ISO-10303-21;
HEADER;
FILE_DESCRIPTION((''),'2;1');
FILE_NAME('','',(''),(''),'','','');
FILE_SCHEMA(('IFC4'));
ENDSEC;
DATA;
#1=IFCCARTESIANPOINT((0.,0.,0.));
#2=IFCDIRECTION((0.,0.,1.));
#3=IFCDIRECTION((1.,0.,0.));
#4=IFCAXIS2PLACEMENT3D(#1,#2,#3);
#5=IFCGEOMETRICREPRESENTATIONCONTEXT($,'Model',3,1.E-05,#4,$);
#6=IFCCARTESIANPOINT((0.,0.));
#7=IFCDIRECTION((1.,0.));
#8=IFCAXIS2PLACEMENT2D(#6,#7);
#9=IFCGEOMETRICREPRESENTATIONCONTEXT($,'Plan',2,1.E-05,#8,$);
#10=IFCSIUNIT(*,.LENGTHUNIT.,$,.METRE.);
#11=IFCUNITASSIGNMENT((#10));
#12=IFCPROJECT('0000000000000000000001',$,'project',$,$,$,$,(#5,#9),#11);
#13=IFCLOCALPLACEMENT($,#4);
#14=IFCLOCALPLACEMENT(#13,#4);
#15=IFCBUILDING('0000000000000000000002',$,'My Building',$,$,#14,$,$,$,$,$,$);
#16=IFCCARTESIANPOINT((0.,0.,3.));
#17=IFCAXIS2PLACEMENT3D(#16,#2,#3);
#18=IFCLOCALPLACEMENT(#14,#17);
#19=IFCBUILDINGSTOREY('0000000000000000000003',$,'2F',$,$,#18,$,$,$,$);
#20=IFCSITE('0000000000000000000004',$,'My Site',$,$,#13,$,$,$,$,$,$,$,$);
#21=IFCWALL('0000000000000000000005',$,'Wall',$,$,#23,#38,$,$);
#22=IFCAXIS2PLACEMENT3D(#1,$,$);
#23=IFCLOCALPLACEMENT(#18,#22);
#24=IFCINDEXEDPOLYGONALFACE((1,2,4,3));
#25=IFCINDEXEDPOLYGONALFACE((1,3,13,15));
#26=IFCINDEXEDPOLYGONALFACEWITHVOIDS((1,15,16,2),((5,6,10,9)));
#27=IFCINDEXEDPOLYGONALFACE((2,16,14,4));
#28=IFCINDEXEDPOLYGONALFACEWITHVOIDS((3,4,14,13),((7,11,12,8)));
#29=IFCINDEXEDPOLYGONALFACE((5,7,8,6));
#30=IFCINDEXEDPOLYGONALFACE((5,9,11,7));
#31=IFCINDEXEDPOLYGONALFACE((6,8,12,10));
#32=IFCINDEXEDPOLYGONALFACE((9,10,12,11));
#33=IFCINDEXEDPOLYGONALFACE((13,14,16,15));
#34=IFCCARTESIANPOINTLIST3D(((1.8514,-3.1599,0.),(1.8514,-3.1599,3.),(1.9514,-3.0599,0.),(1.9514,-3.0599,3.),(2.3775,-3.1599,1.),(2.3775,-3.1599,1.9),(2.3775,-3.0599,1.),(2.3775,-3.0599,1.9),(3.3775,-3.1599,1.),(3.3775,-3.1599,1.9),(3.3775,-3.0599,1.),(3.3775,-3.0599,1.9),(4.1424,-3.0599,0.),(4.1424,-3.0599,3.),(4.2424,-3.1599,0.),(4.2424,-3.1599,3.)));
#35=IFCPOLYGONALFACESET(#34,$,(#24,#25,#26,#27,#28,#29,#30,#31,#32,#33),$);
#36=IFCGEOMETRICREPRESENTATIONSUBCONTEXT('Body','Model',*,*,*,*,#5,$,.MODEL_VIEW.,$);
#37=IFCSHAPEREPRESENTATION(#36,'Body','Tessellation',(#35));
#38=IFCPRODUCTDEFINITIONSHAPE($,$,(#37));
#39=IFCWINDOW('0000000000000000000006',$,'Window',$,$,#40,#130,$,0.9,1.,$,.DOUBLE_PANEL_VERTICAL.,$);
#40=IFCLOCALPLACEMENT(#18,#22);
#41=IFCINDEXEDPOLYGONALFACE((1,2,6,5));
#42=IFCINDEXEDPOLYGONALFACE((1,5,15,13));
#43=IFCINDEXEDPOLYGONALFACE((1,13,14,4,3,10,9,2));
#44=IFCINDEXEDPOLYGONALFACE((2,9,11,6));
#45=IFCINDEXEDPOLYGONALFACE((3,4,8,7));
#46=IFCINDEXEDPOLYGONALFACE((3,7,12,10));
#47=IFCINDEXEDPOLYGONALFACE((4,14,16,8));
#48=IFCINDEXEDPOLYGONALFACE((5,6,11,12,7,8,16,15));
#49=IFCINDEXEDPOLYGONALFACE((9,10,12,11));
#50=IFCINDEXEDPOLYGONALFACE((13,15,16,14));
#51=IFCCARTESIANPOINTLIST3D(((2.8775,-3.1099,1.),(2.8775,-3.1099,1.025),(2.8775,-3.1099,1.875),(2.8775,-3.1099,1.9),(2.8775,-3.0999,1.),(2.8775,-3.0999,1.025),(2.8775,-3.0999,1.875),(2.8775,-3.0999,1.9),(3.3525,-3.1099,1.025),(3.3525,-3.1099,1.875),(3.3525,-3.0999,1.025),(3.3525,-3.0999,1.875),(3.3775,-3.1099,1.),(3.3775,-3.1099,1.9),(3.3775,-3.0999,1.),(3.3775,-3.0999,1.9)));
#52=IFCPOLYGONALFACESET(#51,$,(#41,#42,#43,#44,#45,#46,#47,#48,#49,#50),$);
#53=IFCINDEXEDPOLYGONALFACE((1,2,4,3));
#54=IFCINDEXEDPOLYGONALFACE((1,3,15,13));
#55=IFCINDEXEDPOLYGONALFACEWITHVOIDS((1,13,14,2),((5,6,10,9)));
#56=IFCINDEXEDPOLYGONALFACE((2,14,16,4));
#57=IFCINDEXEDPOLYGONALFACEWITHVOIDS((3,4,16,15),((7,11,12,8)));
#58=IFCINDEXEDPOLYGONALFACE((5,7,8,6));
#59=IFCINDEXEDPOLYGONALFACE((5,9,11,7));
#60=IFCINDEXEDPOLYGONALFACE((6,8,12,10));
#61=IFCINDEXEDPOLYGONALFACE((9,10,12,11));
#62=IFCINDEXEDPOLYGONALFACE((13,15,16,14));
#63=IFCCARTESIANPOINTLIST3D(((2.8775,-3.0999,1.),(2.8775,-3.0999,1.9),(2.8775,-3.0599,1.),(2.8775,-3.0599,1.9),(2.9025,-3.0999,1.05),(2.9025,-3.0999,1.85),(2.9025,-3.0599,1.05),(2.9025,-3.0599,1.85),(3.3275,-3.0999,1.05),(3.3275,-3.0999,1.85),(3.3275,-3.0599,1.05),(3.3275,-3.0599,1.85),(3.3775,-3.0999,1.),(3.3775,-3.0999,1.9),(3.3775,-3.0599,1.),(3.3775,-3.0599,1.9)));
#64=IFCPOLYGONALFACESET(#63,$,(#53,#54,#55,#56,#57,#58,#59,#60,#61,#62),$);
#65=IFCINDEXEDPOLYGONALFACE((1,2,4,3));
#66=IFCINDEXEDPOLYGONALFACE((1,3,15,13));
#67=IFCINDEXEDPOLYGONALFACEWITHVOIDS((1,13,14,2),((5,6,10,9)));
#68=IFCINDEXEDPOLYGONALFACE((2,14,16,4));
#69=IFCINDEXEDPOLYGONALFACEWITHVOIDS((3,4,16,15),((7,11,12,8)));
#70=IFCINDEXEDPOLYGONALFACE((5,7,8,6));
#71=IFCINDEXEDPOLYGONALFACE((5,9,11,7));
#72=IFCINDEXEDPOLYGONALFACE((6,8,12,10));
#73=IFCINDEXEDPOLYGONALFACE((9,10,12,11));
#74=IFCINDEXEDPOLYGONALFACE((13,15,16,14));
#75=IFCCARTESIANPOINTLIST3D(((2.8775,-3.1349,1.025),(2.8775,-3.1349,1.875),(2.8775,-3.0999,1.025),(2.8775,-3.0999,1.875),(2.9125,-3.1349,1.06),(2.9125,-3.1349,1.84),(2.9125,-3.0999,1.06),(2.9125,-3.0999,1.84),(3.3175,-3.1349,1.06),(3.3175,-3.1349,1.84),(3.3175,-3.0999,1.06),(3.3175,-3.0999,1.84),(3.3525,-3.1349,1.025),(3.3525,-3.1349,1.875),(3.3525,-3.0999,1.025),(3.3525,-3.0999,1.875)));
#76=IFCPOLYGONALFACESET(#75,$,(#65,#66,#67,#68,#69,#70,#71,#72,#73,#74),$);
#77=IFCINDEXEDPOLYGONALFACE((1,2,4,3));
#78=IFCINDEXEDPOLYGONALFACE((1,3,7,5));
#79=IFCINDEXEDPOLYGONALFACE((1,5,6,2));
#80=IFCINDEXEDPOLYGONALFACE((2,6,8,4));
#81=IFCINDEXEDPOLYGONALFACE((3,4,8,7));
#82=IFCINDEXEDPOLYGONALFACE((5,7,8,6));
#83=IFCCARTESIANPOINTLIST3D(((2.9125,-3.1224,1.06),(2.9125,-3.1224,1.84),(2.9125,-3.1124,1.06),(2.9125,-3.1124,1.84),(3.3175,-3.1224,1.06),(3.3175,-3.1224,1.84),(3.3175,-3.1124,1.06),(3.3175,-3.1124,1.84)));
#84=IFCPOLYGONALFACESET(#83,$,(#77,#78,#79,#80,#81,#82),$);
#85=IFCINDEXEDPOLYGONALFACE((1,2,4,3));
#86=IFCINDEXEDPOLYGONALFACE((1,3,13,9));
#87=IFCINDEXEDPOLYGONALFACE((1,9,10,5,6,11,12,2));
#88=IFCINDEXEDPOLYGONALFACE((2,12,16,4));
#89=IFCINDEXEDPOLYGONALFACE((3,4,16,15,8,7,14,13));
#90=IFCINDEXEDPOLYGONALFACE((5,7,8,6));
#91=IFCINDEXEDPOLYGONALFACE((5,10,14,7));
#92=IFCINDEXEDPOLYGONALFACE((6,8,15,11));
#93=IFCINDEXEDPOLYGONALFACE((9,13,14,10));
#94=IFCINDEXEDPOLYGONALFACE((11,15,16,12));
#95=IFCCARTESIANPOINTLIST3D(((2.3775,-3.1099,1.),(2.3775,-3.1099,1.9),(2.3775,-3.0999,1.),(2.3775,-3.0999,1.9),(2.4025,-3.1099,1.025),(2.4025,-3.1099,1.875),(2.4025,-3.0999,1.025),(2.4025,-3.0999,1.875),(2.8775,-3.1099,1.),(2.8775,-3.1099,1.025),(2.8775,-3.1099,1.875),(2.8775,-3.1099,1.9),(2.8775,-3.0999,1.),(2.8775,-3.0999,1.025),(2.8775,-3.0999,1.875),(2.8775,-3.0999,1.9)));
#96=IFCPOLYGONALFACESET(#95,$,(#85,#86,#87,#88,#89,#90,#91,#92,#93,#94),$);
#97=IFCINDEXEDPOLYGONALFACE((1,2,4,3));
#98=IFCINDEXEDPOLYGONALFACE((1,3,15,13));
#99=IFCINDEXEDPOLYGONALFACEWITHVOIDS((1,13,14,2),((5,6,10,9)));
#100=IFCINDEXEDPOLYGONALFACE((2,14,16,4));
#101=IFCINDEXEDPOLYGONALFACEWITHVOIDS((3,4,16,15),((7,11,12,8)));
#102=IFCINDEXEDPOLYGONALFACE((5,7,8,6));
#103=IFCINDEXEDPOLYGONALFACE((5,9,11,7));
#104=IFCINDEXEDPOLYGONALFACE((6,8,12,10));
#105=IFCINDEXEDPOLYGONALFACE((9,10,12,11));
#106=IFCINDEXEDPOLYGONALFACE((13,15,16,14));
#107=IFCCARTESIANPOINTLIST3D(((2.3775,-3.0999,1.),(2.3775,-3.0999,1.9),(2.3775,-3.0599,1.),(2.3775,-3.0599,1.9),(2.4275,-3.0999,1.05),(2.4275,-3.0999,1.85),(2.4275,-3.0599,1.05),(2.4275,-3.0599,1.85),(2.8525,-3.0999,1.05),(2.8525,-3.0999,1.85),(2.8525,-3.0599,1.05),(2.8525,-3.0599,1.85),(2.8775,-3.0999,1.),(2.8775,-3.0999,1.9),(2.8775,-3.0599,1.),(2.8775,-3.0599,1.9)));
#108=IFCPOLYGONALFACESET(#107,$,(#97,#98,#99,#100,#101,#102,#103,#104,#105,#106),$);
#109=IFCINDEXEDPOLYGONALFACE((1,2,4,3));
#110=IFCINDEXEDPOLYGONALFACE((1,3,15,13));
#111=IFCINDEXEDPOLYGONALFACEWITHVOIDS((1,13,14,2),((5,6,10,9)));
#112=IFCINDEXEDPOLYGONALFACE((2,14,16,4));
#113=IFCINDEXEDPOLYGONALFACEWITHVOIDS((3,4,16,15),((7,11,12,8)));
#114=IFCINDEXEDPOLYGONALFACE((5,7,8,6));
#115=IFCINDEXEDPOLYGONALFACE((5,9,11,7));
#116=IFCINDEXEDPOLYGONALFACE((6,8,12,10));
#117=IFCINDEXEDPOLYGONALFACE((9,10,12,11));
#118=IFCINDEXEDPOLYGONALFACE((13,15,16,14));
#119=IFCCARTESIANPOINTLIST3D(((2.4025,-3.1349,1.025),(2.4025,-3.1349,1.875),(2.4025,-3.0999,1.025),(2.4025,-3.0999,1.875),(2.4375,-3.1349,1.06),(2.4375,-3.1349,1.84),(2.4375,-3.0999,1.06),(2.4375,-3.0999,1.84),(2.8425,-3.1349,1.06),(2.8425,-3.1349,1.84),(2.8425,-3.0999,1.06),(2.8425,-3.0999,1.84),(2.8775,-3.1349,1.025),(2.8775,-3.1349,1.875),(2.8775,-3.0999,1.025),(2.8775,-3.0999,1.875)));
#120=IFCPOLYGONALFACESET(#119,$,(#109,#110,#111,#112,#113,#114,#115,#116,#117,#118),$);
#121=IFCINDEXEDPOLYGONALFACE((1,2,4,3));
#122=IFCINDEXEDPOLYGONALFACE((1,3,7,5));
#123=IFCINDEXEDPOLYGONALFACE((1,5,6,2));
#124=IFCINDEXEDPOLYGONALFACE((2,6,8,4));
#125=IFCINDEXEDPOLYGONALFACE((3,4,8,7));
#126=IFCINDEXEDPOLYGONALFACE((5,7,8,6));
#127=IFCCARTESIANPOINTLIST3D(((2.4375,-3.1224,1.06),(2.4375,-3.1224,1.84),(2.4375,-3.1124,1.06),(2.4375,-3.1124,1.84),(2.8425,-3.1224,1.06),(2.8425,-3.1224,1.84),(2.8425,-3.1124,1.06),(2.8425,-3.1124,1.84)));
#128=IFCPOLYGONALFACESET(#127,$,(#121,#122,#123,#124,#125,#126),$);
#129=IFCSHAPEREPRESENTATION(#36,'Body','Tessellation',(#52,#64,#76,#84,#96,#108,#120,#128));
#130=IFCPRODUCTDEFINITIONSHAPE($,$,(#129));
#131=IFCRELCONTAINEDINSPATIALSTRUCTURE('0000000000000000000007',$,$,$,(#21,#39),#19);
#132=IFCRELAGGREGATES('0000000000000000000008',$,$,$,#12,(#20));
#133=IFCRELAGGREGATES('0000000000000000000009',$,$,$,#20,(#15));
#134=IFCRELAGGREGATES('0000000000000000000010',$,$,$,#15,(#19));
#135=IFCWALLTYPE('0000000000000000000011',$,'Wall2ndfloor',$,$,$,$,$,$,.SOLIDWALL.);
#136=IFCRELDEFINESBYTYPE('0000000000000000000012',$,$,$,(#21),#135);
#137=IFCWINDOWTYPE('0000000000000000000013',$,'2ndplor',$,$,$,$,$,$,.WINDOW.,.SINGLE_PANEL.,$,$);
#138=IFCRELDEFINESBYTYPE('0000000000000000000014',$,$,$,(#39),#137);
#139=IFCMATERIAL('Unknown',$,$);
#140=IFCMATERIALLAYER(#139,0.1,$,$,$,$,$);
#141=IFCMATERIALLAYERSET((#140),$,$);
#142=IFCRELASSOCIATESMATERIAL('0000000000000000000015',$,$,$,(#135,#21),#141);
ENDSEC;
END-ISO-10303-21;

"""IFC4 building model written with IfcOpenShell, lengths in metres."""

from ifc_helpers import new_model, entity, si_unit, frame, origin_with_axes, origin_2d_with_axis, place, context, subcontext, project, spatial, line, indexed_curve, outline, extrude, shape, source, transform, mapped, material, layer, layer_set, layer_usage, type_object, type_shapes, element, fill, save


model = new_model("IFC4")

# Units and contexts
model_context = context("Model", 3, precision=1e-05, world=origin_with_axes())
plan_context = context("Plan", 2, precision=1e-05, world=origin_2d_with_axis())
body_context_1 = subcontext(model_context, "Body", "Model", "MODEL_VIEW")
body_context_2 = subcontext(plan_context, "Body", "Plan", "PLAN_VIEW")
ifc_project = project(units=[si_unit("LENGTHUNIT", "METRE")], contexts=[model_context, plan_context])

# Site, building, storey
site_placement = place(None, origin_with_axes())
site = spatial("IfcSite", under=ifc_project, at=site_placement, Name="My Site")
building_placement = place(site_placement, origin_with_axes())
building = spatial("IfcBuilding", under=site, at=building_placement, Name="My Building")
storey_placement = place(building_placement, frame((0.0, 0.0, 3.0), z_axis=(0.0, 0.0, 1.0), x_axis=(1.0, 0.0, 0.0)))
storey = spatial("IfcBuildingStorey", under=building, at=storey_placement, Name="2F")

# Shared definitions
ifc_material = material(Name="Unknown")

# Shared definitions
ifc_layer_1 = layer(ifc_material, 0.1)
ifc_layer_set_1 = layer_set([ifc_layer_1])
wall_type = type_object("IfcWallType", Name="Wall2ndfloor", PredefinedType="SOLIDWALL", material=ifc_layer_set_1)

# Shared definitions
shared_shape_1 = source(origin_with_axes(), body_context_1, "Body", "SweptSolid", [
    extrude(outline(indexed_curve([(0.0, 0.0), (1.0, 0.0), (1.0, 0.9), (0.0, 0.9)], segments=[line(1, 2, 3, 4, 1)])), frame((0.0, -0.6, 0.0), z_axis=(0.0, -1.0, 0.0), x_axis=(1.0, 0.0, 0.0)), (0.0, 0.0, -1.0), 1.2),
])
window_type_1 = type_object("IfcWindowType", Name="2ndplor", PartitioningType="SINGLE_PANEL", PredefinedType="WINDOW")
shared_shape_2 = source(origin_with_axes(), body_context_1, "Body", "SweptSolid", [
    extrude(outline(indexed_curve([(0.5, 0.0), (0.0, 0.0), (0.0, 0.9), (0.5, 0.9), (0.5, 0.875), (0.025, 0.875), (0.025, 0.025), (0.5, 0.025)], segments=[line(1, 2, 3, 4, 5, 6, 7, 8, 1)])), frame((0.0, 0.09, 0.0), z_axis=(0.0, -1.0, 0.0), x_axis=(1.0, 0.0, 0.0)), (0.0, 0.0, -1.0), 0.01),
    extrude(outline(indexed_curve([(0.0, 0.0), (0.5, 0.0), (0.5, 0.9), (0.0, 0.9)], segments=[line(1, 2, 3, 4, 1)]), holes=[indexed_curve([(0.05, 0.05), (0.475, 0.05), (0.475, 0.85), (0.05, 0.85)], segments=[line(1, 2, 3, 4, 1)])]), frame((0.0, 0.05, 0.0), z_axis=(0.0, -1.0, 0.0), x_axis=(1.0, 0.0, 0.0)), (0.0, 0.0, -1.0), 0.04),
    extrude(outline(indexed_curve([(0.0, 0.0), (0.475, 0.0), (0.475, 0.85), (0.0, 0.85)], segments=[line(1, 2, 3, 4, 1)]), holes=[indexed_curve([(0.035, 0.035), (0.44, 0.035), (0.44, 0.815), (0.035, 0.815)], segments=[line(1, 2, 3, 4, 1)])]), frame((0.025, 0.09, 0.025), z_axis=(0.0, -1.0, 0.0), x_axis=(1.0, 0.0, 0.0)), (0.0, 0.0, -1.0), 0.035),
    extrude(outline(indexed_curve([(0.035, 0.035), (0.44, 0.035), (0.44, 0.815), (0.035, 0.815)], segments=[line(1, 2, 3, 4, 1)])), frame((0.025, 0.1025, 0.025), z_axis=(0.0, -1.0, 0.0), x_axis=(1.0, 0.0, 0.0)), (0.0, 0.0, -1.0), 0.01),
    extrude(outline(indexed_curve([(0.0, 0.9), (0.5, 0.9), (0.5, 0.0), (0.0, 0.0), (0.0, 0.025), (0.475, 0.025), (0.475, 0.875), (0.0, 0.875)], segments=[line(1, 2, 3, 4, 5, 6, 7, 8, 1)])), frame((0.5, 0.09, 0.0), z_axis=(0.0, -1.0, 0.0), x_axis=(1.0, 0.0, 0.0)), (0.0, 0.0, -1.0), 0.01),
    extrude(outline(indexed_curve([(0.0, 0.0), (0.5, 0.0), (0.5, 0.9), (0.0, 0.9)], segments=[line(1, 2, 3, 4, 1)]), holes=[indexed_curve([(0.025, 0.05), (0.45, 0.05), (0.45, 0.85), (0.025, 0.85)], segments=[line(1, 2, 3, 4, 1)])]), frame((0.5, 0.05, 0.0), z_axis=(0.0, -1.0, 0.0), x_axis=(1.0, 0.0, 0.0)), (0.0, 0.0, -1.0), 0.04),
    extrude(outline(indexed_curve([(0.0, 0.0), (0.475, 0.0), (0.475, 0.85), (0.0, 0.85)], segments=[line(1, 2, 3, 4, 1)]), holes=[indexed_curve([(0.035, 0.035), (0.44, 0.035), (0.44, 0.815), (0.035, 0.815)], segments=[line(1, 2, 3, 4, 1)])]), frame((0.5, 0.09, 0.025), z_axis=(0.0, -1.0, 0.0), x_axis=(1.0, 0.0, 0.0)), (0.0, 0.0, -1.0), 0.035),
    extrude(outline(indexed_curve([(0.035, 0.035), (0.44, 0.035), (0.44, 0.815), (0.035, 0.815)], segments=[line(1, 2, 3, 4, 1)])), frame((0.5, 0.1025, 0.025), z_axis=(0.0, -1.0, 0.0), x_axis=(1.0, 0.0, 0.0)), (0.0, 0.0, -1.0), 0.01),
])
shared_shape_3 = source(origin_with_axes(), body_context_2, "Body", "Curve2D", [
    entity("IfcIndexedPolyCurve", entity("IfcCartesianPointList2D", [[0.05, 0.05], [0.475, 0.05]])),
    entity("IfcIndexedPolyCurve", entity("IfcCartesianPointList2D", [[0.0, 0.1], [0.025, 0.1], [0.025, 0.09], [0.05, 0.09], [0.05, 0.05], [0.0, 0.05]]), [entity("IfcLineIndex", [1, 2, 3, 4, 5, 6, 1])]),
    entity("IfcIndexedPolyCurve", entity("IfcCartesianPointList2D", [[0.5, 0.1], [0.5, 0.1], [0.5, 0.09], [0.475, 0.09], [0.475, 0.05], [0.5, 0.05]])),
    entity("IfcIndexedPolyCurve", entity("IfcCartesianPointList2D", [[0.025, 0.09], [0.06, 0.09], [0.06, 0.125], [0.025, 0.125]]), [entity("IfcLineIndex", [1, 2, 3, 4, 1])]),
    entity("IfcIndexedPolyCurve", entity("IfcCartesianPointList2D", [[0.5, 0.09], [0.465, 0.09], [0.465, 0.125], [0.5, 0.125]]), [entity("IfcLineIndex", [1, 2, 3, 4, 1])]),
    entity("IfcIndexedPolyCurve", entity("IfcCartesianPointList2D", [[0.06, 0.09], [0.465, 0.09]])),
    entity("IfcIndexedPolyCurve", entity("IfcCartesianPointList2D", [[0.06, 0.125], [0.465, 0.125]])),
    entity("IfcIndexedPolyCurve", entity("IfcCartesianPointList2D", [[0.06, 0.1075], [0.465, 0.1075]])),
    entity("IfcIndexedPolyCurve", entity("IfcCartesianPointList2D", [[0.525, 0.05], [0.95, 0.05]])),
    entity("IfcIndexedPolyCurve", entity("IfcCartesianPointList2D", [[0.5, 0.1], [0.5, 0.1], [0.5, 0.09], [0.525, 0.09], [0.525, 0.05], [0.5, 0.05]])),
    entity("IfcIndexedPolyCurve", entity("IfcCartesianPointList2D", [[1.0, 0.1], [0.975, 0.1], [0.975, 0.09], [0.95, 0.09], [0.95, 0.05], [1.0, 0.05]]), [entity("IfcLineIndex", [1, 2, 3, 4, 5, 6, 1])]),
    entity("IfcIndexedPolyCurve", entity("IfcCartesianPointList2D", [[0.5, 0.09], [0.535, 0.09], [0.535, 0.125], [0.5, 0.125]]), [entity("IfcLineIndex", [1, 2, 3, 4, 1])]),
    entity("IfcIndexedPolyCurve", entity("IfcCartesianPointList2D", [[0.975, 0.09], [0.94, 0.09], [0.94, 0.125], [0.975, 0.125]]), [entity("IfcLineIndex", [1, 2, 3, 4, 1])]),
    entity("IfcIndexedPolyCurve", entity("IfcCartesianPointList2D", [[0.535, 0.09], [0.94, 0.09]])),
    entity("IfcIndexedPolyCurve", entity("IfcCartesianPointList2D", [[0.535, 0.125], [0.94, 0.125]])),
    entity("IfcIndexedPolyCurve", entity("IfcCartesianPointList2D", [[0.535, 0.1075], [0.94, 0.1075]])),
])
type_shapes(window_type_1, [shared_shape_2, shared_shape_3])

# Wall, opening, window
ifc_layer_usage_1 = layer_usage(ifc_layer_set_1, "AXIS2", "POSITIVE", 0.0)
wall_1_placement = place(storey_placement, frame((1.8514, -3.1599, 0.0), z_axis=(0.0, 0.0, 1.0), x_axis=(1.0, 0.0, 0.0)))
wall_1 = element("IfcWall", 1, at=wall_1_placement, inside=storey, type_object=wall_type, material=ifc_layer_usage_1, Name="Wall", context=body_context_1, shape_type="SweptSolid", body=[
    extrude(outline(indexed_curve([(0.0, 0.0), (0.1, 0.1), (2.291, 0.1), (2.391, 0.0)], segments=[line(1, 2, 3, 4, 1)])), origin_with_axes(), (0.0, 0.0, 1.0), 3.0),
])
opening_1_placement = place(wall_1_placement, frame((1.5262, 0.15, 1.0), z_axis=(0.0, 0.0, 1.0), x_axis=(-1.0, 0.000001, 0.0)))
opening_1 = element("IfcOpeningElement", 2, at=opening_1_placement, cuts=wall_1, PredefinedType="OPENING", context=body_context_1, shape_type="MappedRepresentation", body=[
    mapped(shared_shape_1, transform((0.0, 0.0, 0.0), x_axis=(1.0, 0.0, 0.0), y_axis=(0.0, 1.0, 0.0), z_axis=(0.0, 0.0, 1.0), scale=1.0)),
])
window_1_placement = place(opening_1_placement, origin_with_axes())
window_1 = element("IfcWindow", 3, at=window_1_placement, inside=storey, type_object=window_type_1, Name="Window", OverallHeight=0.9, OverallWidth=1.0, PartitioningType="DOUBLE_PANEL_VERTICAL", shapes=[
    shape(body_context_1, "Body", "MappedRepresentation", [mapped(shared_shape_2, transform((0.0, 0.0, 0.0), x_axis=(1.0, 0.0, 0.0), y_axis=(0.0, 1.0, 0.0), z_axis=(0.0, 0.0, 1.0), scale=1.0))]),
    shape(body_context_2, "Body", "MappedRepresentation", [mapped(shared_shape_3, transform((0.0, 0.0, 0.0), x_axis=(1.0, 0.0, 0.0), y_axis=(0.0, 1.0, 0.0), z_axis=(0.0, 0.0, 1.0), scale=1.0))]),
])
fill(opening_1, window_1)

save(model, "model.ifc")
